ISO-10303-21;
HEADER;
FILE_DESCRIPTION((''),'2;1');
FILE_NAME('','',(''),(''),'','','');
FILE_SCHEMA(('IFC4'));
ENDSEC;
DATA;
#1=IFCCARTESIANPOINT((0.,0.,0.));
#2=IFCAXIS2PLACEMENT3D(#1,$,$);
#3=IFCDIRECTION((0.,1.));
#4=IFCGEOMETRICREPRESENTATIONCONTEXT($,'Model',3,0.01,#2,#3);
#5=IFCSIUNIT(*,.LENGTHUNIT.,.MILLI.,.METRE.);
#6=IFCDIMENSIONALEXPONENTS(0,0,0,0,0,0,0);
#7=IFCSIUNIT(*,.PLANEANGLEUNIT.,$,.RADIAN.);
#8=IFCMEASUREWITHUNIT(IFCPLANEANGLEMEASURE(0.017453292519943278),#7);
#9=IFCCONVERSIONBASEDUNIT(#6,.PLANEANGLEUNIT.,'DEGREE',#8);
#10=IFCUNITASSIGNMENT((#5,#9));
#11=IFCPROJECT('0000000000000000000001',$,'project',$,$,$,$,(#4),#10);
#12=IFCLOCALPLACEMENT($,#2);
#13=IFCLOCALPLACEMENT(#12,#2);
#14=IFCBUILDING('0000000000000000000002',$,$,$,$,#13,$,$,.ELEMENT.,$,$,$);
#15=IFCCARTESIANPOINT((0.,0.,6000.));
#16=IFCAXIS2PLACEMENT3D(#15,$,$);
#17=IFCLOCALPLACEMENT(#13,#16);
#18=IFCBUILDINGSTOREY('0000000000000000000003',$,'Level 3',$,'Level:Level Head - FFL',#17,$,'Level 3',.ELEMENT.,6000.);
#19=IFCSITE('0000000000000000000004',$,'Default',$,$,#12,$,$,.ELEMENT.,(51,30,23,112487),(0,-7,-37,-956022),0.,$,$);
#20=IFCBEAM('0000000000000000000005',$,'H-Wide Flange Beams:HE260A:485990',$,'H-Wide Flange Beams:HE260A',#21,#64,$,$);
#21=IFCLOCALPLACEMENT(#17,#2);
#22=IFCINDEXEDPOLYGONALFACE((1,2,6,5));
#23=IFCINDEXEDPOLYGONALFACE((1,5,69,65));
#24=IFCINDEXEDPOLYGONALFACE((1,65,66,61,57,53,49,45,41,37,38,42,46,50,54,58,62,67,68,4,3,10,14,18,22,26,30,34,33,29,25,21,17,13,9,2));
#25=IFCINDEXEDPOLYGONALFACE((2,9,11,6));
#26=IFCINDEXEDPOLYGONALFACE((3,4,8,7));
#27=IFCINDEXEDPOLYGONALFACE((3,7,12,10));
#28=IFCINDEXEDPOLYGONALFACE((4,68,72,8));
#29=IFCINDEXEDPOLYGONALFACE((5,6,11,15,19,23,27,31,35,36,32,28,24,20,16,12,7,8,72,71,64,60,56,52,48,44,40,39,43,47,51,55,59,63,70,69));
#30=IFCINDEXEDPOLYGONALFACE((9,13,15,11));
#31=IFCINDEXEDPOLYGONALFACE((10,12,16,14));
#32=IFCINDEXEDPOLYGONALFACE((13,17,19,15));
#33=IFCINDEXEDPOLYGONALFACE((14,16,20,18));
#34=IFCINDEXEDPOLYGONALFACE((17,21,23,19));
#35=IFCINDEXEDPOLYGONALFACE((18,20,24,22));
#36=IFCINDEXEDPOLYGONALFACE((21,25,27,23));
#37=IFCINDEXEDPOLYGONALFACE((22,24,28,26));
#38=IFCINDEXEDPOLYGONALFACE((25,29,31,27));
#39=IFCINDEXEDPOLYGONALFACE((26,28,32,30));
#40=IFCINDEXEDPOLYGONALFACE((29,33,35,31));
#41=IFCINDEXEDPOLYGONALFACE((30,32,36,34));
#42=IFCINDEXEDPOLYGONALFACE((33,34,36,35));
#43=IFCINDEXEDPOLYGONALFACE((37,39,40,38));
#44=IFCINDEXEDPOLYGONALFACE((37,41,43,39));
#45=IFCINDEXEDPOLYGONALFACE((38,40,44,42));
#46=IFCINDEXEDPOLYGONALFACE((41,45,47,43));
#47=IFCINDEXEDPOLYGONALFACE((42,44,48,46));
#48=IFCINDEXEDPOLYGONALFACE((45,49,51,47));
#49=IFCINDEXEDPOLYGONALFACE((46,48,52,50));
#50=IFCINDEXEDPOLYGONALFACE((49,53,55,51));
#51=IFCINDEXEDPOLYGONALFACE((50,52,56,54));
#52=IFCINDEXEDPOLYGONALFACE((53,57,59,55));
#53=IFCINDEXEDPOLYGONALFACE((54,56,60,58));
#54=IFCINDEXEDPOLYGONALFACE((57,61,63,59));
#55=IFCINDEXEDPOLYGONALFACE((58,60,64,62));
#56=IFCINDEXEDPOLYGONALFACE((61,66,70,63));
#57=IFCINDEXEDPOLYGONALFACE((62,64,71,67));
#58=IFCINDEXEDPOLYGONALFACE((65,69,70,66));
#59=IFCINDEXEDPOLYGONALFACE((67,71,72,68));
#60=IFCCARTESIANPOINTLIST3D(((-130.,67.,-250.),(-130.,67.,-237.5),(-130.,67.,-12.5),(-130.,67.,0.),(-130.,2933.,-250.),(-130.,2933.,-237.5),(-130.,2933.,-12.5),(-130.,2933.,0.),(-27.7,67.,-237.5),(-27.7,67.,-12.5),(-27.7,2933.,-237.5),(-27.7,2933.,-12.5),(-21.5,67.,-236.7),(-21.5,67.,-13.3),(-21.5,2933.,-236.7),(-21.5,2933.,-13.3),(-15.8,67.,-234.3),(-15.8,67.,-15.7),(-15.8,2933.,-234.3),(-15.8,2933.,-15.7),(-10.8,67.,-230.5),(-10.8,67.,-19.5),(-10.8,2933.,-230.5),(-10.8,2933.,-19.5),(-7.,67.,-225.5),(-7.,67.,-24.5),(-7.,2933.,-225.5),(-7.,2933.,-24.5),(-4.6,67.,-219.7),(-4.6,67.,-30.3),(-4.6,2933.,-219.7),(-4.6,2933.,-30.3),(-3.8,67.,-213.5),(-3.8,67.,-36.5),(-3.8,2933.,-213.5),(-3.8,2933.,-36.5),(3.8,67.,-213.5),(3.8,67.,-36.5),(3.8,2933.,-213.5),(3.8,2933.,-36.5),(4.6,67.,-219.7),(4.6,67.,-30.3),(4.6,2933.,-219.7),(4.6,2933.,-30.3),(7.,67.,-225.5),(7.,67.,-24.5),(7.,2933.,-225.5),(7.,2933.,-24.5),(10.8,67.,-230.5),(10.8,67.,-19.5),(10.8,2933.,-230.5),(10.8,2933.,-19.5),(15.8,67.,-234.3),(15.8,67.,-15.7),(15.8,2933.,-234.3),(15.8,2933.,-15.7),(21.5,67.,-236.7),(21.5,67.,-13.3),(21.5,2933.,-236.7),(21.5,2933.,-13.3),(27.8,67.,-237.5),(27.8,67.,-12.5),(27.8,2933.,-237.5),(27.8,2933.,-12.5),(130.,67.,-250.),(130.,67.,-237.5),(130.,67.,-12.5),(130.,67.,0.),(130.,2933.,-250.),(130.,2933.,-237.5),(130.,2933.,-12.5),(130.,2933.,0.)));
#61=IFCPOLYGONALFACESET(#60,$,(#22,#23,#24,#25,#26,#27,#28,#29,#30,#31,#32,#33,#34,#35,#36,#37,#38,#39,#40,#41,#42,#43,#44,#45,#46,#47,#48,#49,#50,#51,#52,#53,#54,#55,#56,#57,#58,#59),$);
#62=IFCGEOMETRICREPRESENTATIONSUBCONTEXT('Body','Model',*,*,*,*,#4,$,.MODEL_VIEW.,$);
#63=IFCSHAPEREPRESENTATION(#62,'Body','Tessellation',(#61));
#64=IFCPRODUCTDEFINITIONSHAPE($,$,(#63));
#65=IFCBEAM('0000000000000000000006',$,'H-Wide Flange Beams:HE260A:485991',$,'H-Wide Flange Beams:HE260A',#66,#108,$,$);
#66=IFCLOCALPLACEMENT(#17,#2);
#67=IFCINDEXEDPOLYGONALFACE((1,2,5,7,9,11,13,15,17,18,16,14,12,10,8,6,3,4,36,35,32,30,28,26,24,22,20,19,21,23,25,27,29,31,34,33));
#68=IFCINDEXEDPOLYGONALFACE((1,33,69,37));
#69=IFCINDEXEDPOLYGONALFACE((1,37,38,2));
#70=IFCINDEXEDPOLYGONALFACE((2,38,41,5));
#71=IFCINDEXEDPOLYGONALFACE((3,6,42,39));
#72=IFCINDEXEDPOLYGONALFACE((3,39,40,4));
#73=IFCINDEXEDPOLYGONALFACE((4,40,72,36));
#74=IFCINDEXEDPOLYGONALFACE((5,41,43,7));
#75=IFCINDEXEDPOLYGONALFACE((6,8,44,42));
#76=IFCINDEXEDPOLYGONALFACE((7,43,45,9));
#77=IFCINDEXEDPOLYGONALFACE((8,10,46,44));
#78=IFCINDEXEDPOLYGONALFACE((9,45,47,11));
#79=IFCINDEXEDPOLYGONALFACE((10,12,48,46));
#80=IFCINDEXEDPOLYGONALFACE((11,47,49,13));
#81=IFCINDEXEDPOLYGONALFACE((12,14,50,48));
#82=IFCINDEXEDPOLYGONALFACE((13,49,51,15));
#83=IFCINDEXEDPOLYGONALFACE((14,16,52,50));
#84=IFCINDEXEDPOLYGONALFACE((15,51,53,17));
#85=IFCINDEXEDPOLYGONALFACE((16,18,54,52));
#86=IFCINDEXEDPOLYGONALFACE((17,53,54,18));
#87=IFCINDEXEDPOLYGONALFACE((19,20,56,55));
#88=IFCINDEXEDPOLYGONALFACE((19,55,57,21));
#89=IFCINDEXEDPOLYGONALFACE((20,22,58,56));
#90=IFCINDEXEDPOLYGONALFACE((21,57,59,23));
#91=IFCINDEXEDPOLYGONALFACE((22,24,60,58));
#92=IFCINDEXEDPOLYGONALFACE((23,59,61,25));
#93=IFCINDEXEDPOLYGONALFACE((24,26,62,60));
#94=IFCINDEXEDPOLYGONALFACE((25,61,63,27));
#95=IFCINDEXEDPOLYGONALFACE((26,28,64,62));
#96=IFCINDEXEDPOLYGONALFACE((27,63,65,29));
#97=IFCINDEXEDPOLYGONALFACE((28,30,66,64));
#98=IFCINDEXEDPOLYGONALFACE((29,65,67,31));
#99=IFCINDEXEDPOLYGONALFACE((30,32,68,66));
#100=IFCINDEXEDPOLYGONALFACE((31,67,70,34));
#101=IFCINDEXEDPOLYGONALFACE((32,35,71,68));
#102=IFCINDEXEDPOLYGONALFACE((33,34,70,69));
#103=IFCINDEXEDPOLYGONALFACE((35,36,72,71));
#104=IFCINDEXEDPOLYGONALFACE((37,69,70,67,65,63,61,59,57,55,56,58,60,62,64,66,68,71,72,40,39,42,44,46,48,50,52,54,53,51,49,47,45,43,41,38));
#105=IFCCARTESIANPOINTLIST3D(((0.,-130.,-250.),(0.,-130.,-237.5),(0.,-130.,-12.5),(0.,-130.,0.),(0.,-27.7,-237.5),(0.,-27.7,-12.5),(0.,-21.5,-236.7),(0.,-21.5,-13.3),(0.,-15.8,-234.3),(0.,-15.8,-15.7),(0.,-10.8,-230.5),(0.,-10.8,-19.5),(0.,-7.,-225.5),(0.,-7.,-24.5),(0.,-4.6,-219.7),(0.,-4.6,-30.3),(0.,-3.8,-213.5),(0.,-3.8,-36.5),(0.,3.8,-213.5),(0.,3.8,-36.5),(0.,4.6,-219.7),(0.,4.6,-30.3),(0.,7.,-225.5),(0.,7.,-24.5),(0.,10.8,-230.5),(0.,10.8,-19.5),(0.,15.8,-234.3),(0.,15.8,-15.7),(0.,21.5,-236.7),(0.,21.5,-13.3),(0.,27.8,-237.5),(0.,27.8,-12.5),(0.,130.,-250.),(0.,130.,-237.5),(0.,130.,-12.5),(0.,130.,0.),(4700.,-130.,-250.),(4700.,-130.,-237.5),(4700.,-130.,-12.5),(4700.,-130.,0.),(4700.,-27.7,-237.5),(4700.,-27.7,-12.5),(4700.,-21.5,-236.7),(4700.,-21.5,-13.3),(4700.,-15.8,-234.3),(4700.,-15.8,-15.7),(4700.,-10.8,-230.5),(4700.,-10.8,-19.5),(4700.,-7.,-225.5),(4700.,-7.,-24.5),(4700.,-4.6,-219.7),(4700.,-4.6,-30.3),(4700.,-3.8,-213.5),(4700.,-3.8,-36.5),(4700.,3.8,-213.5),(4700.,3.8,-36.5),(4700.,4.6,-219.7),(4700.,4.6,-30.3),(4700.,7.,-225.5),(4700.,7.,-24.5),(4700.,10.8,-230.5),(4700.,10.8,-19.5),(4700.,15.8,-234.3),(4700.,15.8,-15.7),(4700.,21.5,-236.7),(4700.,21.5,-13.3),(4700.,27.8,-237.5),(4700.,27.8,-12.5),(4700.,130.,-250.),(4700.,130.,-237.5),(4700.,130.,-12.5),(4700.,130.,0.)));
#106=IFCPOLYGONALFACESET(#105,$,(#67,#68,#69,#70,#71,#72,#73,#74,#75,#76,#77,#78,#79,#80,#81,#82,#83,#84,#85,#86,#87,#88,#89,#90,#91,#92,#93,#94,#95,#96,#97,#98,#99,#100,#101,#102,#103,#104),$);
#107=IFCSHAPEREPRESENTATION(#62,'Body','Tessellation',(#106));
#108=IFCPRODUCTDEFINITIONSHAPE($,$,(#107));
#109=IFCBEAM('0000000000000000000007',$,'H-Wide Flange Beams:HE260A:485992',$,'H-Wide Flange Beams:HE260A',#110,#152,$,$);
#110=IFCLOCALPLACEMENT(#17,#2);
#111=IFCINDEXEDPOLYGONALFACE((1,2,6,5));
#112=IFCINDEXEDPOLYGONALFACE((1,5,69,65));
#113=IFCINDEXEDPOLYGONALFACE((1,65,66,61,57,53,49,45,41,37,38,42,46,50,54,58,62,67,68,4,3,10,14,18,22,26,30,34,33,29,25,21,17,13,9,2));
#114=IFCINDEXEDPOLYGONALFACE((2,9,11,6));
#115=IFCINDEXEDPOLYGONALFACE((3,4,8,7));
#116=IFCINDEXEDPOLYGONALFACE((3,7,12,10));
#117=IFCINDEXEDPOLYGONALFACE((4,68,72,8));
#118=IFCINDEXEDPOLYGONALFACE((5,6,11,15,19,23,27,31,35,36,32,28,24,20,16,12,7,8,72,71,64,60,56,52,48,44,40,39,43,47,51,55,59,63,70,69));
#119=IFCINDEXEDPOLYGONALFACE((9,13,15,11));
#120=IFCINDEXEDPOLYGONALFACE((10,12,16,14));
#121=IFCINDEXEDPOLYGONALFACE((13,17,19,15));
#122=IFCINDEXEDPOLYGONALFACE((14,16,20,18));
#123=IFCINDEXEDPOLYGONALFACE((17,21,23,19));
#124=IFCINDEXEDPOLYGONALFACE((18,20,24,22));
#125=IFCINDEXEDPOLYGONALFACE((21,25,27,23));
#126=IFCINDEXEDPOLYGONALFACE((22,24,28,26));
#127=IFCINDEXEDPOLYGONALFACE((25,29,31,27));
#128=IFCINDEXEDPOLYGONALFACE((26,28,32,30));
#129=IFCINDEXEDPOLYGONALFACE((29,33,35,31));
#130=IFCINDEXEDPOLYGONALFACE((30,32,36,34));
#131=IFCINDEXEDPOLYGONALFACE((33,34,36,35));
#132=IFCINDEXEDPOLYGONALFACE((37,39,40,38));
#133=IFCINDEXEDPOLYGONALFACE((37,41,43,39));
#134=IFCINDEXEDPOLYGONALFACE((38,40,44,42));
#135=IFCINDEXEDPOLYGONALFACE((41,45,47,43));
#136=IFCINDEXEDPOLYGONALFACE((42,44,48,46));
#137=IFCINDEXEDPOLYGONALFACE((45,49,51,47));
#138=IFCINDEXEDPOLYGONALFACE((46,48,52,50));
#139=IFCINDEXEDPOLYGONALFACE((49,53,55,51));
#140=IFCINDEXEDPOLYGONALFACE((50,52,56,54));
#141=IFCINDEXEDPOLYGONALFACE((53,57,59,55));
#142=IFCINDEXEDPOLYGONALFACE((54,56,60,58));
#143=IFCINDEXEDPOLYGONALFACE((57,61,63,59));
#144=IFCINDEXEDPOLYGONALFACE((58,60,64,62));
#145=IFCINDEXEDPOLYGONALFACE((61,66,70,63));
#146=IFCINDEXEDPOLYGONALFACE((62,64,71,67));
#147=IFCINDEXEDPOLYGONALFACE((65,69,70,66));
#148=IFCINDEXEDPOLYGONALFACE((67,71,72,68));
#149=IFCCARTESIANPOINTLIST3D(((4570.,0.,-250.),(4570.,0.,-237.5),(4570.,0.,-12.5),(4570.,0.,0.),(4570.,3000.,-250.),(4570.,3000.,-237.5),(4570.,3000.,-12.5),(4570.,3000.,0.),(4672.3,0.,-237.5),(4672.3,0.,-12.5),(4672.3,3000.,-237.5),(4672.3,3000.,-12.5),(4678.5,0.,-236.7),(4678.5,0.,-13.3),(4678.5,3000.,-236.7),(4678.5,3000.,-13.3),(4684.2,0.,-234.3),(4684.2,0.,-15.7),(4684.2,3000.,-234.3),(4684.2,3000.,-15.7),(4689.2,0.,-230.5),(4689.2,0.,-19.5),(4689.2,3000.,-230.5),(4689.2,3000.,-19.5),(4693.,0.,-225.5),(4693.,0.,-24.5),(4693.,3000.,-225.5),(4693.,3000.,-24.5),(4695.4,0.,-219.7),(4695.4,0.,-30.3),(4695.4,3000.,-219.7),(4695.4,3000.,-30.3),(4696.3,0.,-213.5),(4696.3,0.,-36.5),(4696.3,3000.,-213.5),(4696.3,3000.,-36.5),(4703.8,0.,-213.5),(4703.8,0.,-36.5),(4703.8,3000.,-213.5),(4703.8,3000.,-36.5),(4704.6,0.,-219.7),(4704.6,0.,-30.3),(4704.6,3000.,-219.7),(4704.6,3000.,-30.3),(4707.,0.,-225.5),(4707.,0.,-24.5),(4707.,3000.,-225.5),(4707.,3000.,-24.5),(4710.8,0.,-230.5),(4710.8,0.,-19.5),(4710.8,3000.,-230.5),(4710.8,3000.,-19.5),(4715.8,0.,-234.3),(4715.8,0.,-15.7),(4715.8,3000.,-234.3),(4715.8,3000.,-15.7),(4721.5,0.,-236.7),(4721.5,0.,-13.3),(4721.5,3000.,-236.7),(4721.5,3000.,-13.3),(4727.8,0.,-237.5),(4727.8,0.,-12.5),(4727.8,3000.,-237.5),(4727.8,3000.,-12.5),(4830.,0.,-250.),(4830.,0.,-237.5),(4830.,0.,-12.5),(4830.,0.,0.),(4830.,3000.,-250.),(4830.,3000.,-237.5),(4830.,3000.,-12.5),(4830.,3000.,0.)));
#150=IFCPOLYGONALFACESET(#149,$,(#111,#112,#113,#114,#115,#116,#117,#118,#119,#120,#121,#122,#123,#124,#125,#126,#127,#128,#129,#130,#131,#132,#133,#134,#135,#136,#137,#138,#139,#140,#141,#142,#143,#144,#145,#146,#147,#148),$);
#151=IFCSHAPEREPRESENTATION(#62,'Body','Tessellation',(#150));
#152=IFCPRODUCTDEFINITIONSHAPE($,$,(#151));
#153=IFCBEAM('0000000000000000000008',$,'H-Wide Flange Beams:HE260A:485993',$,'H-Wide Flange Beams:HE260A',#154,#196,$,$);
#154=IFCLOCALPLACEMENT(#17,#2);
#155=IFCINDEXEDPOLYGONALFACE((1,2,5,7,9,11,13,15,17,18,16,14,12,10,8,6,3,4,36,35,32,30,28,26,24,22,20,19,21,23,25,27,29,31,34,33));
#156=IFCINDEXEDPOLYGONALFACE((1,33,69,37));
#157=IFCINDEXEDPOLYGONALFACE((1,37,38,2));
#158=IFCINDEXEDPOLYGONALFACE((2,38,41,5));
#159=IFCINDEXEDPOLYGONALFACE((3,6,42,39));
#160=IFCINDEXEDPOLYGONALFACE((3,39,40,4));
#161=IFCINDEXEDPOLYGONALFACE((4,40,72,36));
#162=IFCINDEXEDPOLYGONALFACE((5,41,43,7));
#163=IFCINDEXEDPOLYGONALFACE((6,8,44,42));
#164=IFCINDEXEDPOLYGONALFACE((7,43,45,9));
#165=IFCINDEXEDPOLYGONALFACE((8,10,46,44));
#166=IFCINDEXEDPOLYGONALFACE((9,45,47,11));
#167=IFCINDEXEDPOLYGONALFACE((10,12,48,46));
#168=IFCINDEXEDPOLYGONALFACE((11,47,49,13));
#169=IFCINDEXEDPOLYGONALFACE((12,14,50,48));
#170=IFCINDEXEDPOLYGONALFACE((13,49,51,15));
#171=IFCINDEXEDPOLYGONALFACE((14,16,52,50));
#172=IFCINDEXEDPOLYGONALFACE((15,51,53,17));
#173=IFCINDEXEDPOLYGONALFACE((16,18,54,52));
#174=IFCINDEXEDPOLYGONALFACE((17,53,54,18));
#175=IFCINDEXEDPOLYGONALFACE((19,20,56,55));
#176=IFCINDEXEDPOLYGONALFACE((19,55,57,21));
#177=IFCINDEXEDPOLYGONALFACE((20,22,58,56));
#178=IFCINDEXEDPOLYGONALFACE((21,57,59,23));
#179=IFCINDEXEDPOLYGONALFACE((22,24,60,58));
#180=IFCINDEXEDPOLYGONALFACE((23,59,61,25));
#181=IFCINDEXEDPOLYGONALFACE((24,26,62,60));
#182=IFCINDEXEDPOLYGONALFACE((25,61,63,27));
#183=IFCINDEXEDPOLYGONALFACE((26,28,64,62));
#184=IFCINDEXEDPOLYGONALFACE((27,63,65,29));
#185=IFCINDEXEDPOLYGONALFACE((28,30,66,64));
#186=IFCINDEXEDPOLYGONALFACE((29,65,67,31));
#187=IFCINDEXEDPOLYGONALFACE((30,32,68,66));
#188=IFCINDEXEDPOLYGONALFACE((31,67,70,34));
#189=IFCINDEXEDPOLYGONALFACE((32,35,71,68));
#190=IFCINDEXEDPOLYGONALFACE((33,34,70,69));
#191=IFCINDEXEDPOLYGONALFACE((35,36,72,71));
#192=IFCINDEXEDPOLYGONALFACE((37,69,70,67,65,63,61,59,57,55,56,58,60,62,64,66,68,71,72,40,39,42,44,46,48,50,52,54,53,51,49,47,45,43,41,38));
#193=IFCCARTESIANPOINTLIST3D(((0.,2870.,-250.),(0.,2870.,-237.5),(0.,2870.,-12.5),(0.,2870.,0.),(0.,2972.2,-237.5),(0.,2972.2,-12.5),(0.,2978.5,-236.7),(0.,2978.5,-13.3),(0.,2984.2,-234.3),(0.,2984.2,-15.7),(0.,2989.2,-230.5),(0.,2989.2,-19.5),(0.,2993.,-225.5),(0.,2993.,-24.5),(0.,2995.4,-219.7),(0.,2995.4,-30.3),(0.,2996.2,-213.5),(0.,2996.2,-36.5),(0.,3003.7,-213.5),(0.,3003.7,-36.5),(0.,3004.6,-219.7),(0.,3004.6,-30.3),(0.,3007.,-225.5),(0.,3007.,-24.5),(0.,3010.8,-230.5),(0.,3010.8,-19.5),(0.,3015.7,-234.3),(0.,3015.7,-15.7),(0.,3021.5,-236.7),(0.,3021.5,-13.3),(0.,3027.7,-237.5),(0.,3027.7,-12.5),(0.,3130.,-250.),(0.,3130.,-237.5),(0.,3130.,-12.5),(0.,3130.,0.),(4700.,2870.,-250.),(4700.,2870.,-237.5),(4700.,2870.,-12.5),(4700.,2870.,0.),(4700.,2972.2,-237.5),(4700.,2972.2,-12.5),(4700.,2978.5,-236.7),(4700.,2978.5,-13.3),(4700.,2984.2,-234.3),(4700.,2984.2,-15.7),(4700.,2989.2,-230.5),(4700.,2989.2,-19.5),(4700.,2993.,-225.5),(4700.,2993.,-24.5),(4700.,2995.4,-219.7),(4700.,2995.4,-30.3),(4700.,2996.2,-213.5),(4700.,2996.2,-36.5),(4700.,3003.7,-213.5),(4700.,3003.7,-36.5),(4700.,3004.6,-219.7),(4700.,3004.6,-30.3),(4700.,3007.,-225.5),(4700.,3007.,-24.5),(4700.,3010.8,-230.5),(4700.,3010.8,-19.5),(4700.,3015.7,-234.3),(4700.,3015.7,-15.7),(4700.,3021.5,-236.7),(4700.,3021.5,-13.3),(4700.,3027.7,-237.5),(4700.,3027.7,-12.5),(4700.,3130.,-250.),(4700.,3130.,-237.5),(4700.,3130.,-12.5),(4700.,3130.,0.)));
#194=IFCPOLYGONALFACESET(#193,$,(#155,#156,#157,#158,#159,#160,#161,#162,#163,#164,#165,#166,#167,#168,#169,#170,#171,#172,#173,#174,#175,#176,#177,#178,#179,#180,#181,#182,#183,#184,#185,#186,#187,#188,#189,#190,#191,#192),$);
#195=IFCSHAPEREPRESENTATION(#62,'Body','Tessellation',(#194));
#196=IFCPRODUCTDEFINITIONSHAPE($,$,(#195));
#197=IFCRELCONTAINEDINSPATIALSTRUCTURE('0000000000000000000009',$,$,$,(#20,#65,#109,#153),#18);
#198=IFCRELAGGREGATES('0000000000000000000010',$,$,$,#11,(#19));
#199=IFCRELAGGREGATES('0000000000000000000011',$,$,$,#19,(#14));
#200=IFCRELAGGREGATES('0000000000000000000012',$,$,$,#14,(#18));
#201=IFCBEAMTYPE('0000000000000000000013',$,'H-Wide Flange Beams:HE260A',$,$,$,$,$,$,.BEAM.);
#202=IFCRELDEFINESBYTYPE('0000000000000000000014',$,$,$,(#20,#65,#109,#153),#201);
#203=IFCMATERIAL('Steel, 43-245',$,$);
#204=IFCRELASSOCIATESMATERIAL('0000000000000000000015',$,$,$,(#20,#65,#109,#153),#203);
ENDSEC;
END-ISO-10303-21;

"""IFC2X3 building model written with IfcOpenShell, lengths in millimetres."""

from ifc_helpers import new_model, entity, si_unit, converted_unit, direction, frame, frame_2d, origin, place, context, subcontext, project, spatial, i_section, extrude, material, type_object, element, save


model = new_model("IFC2X3")

# Units and contexts
model_context = context("Model", 3, precision=0.01, world=origin(), true_north=direction((0.0, 1.0)))
body_context = subcontext(model_context, "Body", "Model", "MODEL_VIEW")
ifc_project = project(units=[si_unit("LENGTHUNIT", "METRE", prefix="MILLI"), converted_unit("PLANEANGLEUNIT", "DEGREE", entity("IfcPlaneAngleMeasure", 0.017453292519943278), si_unit("PLANEANGLEUNIT", "RADIAN"), dimensions=[0, 0, 0, 0, 0, 0, 0])], contexts=[model_context])

# Site, building, storey
site_placement = place(None, origin())
site = spatial("IfcSite", under=ifc_project, at=site_placement, Name="Default", CompositionType="ELEMENT", RefLatitude=(51, 30, 23, 112487), RefLongitude=(0, -7, -37, -956022), RefElevation=0.0)
building_placement = place(site_placement, origin())
building = spatial("IfcBuilding", under=site, at=building_placement, CompositionType="ELEMENT")
storey_placement = place(building_placement, frame((0.0, 0.0, 6000.0)))
storey = spatial("IfcBuildingStorey", under=building, at=storey_placement, Name="Level 3", ObjectType="Level:Level Head - FFL", LongName="Level 3", CompositionType="ELEMENT", Elevation=6000.0)

# Beams
ifc_material = material(Name="Steel, 43-245")
beam_type_1 = type_object("IfcBeamType", Name="H-Wide Flange Beams:HE260A", PredefinedType="BEAM")
beam_1_placement = place(storey_placement, frame((0.0, 3000.0, 0.0), z_axis=(0.0, 0.0, 1.0), x_axis=(0.0, -1.0, 0.0)))
element("IfcBeam", 1, at=beam_1_placement, inside=storey, type_object=beam_type_1, material=ifc_material, Name="H-Wide Flange Beams:HE260A:485990", ObjectType="H-Wide Flange Beams:HE260A", context=body_context, shape_type="SweptSolid", body=[
    extrude(i_section(OverallWidth=260.0, OverallDepth=250.0, WebThickness=7.5, FlangeThickness=12.5, FilletRadius=24.0, at=frame_2d((0.0, 0.0), x_axis=(0.0, 1.0))), frame((67.0, 0.0, -125.0), z_axis=(1.0, 0.0, 0.0), x_axis=(0.0, 0.0, -1.0)), (0.0, 0.0, 1.0), 2866.0),
])
beam_2_placement = place(storey_placement, origin())
element("IfcBeam", 2, at=beam_2_placement, inside=storey, type_object=beam_type_1, material=ifc_material, Name="H-Wide Flange Beams:HE260A:485991", ObjectType="H-Wide Flange Beams:HE260A", context=body_context, shape_type="SweptSolid", body=[
    extrude(i_section(OverallWidth=260.0, OverallDepth=250.0, WebThickness=7.5, FlangeThickness=12.5, FilletRadius=24.0, at=frame_2d((0.0, 0.0), x_axis=(0.0, 1.0))), frame((0.0, 0.0, -125.0), z_axis=(1.0, 0.0, 0.0), x_axis=(0.0, 0.0, -1.0)), (0.0, 0.0, 1.0), 4700.0),
])
beam_3_placement = place(storey_placement, frame((4700.0, 0.0, 0.0), z_axis=(0.0, 0.0, 1.0), x_axis=(0.0, 1.0, 0.0)))
element("IfcBeam", 3, at=beam_3_placement, inside=storey, type_object=beam_type_1, material=ifc_material, Name="H-Wide Flange Beams:HE260A:485992", ObjectType="H-Wide Flange Beams:HE260A", context=body_context, shape_type="SweptSolid", body=[
    extrude(i_section(OverallWidth=260.0, OverallDepth=250.0, WebThickness=7.5, FlangeThickness=12.5, FilletRadius=24.0, at=frame_2d((0.0, 0.0), x_axis=(0.0, 1.0))), frame((0.0, 0.0, -125.0), z_axis=(1.0, 0.0, 0.0), x_axis=(0.0, 0.0, -1.0)), (0.0, 0.0, 1.0), 3000.0),
])
beam_4_placement = place(storey_placement, frame((4700.0, 3000.0, 0.0), z_axis=(0.0, 0.0, 1.0), x_axis=(-1.0, 0.0, 0.0)))
element("IfcBeam", 4, at=beam_4_placement, inside=storey, type_object=beam_type_1, material=ifc_material, Name="H-Wide Flange Beams:HE260A:485993", ObjectType="H-Wide Flange Beams:HE260A", context=body_context, shape_type="SweptSolid", body=[
    extrude(i_section(OverallWidth=260.0, OverallDepth=250.0, WebThickness=7.5, FlangeThickness=12.5, FilletRadius=24.0, at=frame_2d((0.0, 0.0), x_axis=(0.0, 1.0))), frame((0.0, 0.0, -125.0), z_axis=(1.0, 0.0, 0.0), x_axis=(0.0, 0.0, -1.0)), (0.0, 0.0, 1.0), 4700.0),
])

save(model, "model.ifc")
